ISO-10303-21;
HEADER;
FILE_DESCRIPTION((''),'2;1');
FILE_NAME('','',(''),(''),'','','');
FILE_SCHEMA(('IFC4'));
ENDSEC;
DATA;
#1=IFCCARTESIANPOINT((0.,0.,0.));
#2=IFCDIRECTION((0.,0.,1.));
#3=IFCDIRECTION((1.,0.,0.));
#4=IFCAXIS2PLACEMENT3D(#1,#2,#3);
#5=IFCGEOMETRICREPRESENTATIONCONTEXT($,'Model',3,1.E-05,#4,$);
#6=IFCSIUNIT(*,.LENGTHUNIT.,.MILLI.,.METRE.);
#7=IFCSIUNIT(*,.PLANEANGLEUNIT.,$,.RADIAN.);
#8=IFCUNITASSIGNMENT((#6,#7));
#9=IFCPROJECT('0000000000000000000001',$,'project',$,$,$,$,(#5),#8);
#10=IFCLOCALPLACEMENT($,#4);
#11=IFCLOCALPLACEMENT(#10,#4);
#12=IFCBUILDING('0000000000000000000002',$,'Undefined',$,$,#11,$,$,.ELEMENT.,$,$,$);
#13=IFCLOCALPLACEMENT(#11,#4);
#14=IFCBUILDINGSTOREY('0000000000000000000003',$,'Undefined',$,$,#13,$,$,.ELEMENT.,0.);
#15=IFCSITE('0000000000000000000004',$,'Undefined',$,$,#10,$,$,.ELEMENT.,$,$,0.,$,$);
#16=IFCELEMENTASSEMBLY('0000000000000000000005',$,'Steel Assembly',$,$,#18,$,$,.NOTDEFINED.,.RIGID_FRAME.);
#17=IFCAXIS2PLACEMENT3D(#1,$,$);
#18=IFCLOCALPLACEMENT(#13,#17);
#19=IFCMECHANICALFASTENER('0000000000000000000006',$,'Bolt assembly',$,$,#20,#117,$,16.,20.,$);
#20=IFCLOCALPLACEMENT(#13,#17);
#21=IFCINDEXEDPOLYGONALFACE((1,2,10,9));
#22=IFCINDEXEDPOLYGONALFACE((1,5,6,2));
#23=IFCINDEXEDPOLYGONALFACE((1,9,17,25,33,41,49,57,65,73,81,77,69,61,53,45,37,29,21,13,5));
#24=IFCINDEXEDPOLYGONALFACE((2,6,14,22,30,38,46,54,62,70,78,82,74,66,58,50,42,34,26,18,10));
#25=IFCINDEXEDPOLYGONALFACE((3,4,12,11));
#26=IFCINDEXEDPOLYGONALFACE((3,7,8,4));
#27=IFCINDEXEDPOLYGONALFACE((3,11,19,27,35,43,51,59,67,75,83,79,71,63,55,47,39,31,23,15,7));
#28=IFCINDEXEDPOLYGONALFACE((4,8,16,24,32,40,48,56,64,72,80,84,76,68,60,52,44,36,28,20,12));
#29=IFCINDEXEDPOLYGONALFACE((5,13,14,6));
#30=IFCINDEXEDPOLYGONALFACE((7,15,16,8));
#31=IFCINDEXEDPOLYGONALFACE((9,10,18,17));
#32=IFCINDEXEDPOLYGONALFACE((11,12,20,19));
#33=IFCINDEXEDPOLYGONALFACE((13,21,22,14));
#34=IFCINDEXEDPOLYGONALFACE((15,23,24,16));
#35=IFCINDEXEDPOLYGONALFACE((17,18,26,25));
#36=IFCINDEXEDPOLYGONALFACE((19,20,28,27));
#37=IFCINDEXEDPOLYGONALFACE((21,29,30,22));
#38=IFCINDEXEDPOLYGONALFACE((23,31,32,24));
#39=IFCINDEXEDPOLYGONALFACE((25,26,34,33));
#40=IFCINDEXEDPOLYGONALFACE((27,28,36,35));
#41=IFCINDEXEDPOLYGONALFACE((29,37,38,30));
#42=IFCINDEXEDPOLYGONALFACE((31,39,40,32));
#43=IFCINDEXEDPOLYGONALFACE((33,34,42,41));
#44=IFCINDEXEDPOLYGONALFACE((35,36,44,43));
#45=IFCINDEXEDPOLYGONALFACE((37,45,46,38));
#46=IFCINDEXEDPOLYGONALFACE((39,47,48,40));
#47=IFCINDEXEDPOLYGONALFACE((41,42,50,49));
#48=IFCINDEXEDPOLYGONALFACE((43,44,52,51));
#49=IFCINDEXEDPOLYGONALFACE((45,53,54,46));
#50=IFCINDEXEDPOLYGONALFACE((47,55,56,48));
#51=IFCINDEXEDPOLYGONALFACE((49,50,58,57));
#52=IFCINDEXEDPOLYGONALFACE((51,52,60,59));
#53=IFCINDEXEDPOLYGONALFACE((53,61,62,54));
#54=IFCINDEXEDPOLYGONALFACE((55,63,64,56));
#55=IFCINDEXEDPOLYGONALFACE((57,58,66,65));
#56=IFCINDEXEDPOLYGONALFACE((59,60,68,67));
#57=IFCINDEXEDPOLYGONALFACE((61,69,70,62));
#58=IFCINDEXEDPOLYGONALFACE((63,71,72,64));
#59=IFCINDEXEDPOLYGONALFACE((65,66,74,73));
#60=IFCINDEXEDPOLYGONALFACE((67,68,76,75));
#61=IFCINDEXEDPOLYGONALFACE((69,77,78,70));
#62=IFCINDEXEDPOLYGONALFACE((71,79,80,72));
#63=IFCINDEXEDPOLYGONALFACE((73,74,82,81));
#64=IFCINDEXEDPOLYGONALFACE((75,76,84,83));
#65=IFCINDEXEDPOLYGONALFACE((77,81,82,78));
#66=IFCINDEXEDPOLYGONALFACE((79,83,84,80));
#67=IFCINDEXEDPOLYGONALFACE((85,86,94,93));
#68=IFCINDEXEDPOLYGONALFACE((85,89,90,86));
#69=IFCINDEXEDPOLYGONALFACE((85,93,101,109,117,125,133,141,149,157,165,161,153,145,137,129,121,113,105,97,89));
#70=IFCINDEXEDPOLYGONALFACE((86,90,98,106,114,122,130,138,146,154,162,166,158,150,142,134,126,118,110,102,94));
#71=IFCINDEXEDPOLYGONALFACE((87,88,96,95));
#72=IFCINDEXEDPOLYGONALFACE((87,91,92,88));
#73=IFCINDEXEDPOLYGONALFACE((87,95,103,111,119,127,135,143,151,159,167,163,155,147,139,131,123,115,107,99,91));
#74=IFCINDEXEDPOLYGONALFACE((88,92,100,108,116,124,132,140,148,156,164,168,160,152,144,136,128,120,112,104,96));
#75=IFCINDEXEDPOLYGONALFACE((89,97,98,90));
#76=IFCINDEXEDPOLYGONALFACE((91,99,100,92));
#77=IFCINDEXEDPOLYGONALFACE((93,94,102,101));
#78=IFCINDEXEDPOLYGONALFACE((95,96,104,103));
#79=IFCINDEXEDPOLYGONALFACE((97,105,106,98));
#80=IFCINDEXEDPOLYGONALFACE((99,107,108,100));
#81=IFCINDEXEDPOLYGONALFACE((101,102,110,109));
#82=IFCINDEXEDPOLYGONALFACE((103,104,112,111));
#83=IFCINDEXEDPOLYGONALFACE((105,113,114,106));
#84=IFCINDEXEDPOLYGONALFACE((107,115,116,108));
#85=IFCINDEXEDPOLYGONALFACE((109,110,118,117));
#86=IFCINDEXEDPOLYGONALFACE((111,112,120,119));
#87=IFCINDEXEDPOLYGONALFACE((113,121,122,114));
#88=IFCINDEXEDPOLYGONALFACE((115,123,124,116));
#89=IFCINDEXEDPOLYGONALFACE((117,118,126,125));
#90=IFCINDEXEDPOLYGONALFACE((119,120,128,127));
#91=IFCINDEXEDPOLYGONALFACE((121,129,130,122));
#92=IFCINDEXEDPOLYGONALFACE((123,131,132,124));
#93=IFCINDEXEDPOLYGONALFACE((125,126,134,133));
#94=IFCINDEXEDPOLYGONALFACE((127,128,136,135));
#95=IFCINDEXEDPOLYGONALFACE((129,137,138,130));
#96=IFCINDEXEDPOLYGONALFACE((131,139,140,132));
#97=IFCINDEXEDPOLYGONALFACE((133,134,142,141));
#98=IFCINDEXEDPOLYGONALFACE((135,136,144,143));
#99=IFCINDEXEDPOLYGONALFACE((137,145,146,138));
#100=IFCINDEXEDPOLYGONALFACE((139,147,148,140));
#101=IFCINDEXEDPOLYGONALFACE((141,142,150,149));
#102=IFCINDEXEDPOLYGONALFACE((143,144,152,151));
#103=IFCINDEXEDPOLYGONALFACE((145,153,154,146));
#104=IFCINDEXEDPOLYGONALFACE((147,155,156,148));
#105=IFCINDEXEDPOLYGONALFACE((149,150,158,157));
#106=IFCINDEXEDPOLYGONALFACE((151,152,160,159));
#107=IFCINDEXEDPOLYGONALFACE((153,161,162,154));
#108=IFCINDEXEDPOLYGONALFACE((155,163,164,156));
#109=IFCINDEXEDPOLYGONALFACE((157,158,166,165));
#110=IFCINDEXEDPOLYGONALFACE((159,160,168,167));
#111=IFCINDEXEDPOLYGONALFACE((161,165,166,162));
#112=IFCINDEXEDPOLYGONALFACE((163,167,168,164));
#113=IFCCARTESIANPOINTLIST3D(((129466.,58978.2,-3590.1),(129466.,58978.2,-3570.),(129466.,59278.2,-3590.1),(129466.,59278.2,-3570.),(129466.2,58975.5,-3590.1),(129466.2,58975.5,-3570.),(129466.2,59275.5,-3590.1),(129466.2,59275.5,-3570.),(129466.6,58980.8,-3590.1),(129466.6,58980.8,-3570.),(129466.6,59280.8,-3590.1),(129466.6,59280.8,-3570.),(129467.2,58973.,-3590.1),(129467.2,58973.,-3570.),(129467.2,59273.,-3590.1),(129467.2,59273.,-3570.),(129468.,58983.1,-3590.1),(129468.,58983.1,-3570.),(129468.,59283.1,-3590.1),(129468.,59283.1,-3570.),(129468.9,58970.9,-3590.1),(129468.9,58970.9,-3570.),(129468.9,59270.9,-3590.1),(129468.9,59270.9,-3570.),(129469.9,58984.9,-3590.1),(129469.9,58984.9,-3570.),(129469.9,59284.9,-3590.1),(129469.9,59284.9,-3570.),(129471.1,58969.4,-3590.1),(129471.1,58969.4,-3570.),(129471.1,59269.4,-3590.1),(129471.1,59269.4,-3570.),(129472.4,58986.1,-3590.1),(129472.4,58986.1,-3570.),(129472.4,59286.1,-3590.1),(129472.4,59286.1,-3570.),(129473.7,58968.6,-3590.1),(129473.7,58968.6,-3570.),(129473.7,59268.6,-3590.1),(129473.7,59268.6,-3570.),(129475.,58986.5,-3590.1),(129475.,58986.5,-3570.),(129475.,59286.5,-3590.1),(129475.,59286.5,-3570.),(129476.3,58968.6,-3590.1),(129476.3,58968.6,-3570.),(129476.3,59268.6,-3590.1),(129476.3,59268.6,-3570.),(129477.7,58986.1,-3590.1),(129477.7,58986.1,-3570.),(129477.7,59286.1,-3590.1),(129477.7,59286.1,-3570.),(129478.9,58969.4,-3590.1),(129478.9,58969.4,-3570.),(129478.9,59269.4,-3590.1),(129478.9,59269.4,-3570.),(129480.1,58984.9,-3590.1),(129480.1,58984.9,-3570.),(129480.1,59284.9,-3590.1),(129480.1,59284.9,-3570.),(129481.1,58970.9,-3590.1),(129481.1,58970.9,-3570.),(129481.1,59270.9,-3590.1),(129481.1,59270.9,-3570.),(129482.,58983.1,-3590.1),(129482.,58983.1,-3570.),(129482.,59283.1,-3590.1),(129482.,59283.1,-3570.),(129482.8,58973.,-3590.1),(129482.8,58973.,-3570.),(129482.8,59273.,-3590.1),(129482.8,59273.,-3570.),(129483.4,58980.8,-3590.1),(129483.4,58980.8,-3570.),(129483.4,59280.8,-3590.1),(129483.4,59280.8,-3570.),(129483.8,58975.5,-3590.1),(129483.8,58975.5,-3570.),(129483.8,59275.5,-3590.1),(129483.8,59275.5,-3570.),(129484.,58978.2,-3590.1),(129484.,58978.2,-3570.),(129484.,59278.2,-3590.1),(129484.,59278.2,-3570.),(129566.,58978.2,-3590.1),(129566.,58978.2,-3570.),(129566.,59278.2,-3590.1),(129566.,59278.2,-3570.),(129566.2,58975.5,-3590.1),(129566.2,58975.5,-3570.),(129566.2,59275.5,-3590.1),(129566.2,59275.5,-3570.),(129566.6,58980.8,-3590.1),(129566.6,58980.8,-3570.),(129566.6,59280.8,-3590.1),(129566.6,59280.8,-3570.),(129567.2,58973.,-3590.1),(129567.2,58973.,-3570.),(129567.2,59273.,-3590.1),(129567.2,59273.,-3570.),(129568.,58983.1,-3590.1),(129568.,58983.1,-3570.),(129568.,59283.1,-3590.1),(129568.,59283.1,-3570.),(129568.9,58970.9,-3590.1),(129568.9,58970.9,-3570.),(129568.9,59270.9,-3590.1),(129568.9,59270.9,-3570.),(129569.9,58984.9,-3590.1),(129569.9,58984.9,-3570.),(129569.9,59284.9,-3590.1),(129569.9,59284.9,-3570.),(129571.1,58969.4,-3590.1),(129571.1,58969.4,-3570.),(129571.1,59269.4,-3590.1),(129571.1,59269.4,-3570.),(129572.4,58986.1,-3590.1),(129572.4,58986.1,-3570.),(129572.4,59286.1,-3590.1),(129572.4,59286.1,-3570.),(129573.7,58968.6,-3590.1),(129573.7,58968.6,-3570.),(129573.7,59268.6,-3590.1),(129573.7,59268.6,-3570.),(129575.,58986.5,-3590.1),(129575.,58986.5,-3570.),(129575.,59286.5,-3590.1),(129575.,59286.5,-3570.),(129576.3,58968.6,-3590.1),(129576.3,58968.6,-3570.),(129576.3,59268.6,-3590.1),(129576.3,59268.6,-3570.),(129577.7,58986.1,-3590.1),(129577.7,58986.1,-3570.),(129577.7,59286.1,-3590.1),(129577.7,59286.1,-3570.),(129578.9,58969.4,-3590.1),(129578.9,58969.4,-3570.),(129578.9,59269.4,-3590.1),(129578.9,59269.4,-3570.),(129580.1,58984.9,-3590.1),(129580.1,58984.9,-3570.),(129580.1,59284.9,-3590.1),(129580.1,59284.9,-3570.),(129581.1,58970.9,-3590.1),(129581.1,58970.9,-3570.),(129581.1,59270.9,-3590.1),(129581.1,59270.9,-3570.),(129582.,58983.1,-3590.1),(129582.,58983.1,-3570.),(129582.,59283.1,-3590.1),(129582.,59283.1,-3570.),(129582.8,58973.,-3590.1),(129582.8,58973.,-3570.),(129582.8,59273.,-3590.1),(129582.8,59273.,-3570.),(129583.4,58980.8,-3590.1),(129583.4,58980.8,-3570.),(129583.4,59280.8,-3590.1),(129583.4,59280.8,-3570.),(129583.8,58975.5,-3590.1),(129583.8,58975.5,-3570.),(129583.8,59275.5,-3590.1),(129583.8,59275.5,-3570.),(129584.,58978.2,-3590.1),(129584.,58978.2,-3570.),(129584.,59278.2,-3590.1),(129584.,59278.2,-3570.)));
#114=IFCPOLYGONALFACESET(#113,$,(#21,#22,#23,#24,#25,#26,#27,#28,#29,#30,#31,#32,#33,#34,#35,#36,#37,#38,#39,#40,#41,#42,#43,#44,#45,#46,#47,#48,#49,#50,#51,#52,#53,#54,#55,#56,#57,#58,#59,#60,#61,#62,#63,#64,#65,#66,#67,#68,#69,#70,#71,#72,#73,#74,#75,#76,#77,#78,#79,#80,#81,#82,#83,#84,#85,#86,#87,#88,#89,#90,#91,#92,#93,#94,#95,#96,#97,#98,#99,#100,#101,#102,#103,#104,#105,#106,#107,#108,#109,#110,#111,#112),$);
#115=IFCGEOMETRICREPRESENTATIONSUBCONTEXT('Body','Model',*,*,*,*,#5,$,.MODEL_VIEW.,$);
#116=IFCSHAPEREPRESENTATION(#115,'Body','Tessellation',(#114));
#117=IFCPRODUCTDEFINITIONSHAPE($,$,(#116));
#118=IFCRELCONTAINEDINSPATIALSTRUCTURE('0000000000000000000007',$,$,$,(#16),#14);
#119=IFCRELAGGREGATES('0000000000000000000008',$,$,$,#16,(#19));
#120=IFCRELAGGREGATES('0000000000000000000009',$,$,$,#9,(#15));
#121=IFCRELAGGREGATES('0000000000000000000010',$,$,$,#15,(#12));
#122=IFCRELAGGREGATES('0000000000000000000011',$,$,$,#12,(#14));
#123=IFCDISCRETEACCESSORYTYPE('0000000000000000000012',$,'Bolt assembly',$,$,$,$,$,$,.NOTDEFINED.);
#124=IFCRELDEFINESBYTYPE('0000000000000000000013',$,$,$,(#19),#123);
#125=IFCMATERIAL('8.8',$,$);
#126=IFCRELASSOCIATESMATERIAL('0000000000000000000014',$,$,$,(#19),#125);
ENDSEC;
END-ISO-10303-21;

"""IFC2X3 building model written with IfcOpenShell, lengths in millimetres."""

from ifc_helpers import new_model, si_unit, frame, origin_with_axes, origin_2d_with_axis, place, context, subcontext, project, spatial, circle, extrude, source, transform, mapped, material, type_object, element, aggregate, save


model = new_model("IFC2X3")

# Units and contexts
model_context = context("Model", 3, precision=1e-05, world=origin_with_axes())
body_context = subcontext(model_context, "Body", "Model", "MODEL_VIEW")
ifc_project = project(units=[si_unit("LENGTHUNIT", "METRE", prefix="MILLI"), si_unit("PLANEANGLEUNIT", "RADIAN")], contexts=[model_context])

# Site, building, storey
site_placement = place(None, origin_with_axes())
site = spatial("IfcSite", under=ifc_project, at=site_placement, Name="Undefined", CompositionType="ELEMENT", RefElevation=0.0)
building_placement = place(site_placement, origin_with_axes())
building = spatial("IfcBuilding", under=site, at=building_placement, Name="Undefined", CompositionType="ELEMENT")
storey_placement = place(building_placement, origin_with_axes())
storey = spatial("IfcBuildingStorey", under=building, at=storey_placement, Name="Undefined", CompositionType="ELEMENT", Elevation=0.0)

# Shared definitions
ifc_material_1 = material(Name="8.8")
discrete_accessory_type_1 = type_object("IfcDiscreteAccessoryType", Name="Bolt assembly")

# Element assembly, mechanical fastener
assembly_1_placement = place(storey_placement, origin_with_axes())
assembly_1 = element("IfcElementAssembly", 1, at=assembly_1_placement, inside=storey, Name="Steel Assembly", AssemblyPlace="NOTDEFINED", PredefinedType="RIGID_FRAME")
shared_shape_1 = source(origin_with_axes(), body_context, "Body", "SweptSolid", [
    extrude(circle(Radius=9.0, at=origin_2d_with_axis()), frame((0.0, -20.0, 0.0), z_axis=(0.0, 1.0, 0.0), x_axis=(1.0, 0.0, 0.0)), (0.0, 0.0, 1.0), 20.1),
])
mechanical_fastener_1_placement = place(assembly_1_placement, frame((129525.0, 58977.5, -3590.0), z_axis=(-1.0, 0.0, 0.0), x_axis=(0.0, 1.0, 0.0)))
mechanical_fastener_1 = element("IfcMechanicalFastener", 2, at=mechanical_fastener_1_placement, type_object=discrete_accessory_type_1, material=ifc_material_1, Name="Bolt assembly", NominalDiameter=16.0, NominalLength=20.0, context=body_context, shape_type="MappedRepresentation", body=[
    mapped(shared_shape_1, transform((0.0, 0.0, -50.0))),
    mapped(shared_shape_1, transform((300.0, 0.0, -50.0))),
    mapped(shared_shape_1, transform((0.0, 0.0, 50.0))),
    mapped(shared_shape_1, transform((300.0, 0.0, 50.0))),
])

aggregate(assembly_1, [mechanical_fastener_1])

save(model, "model.ifc")
